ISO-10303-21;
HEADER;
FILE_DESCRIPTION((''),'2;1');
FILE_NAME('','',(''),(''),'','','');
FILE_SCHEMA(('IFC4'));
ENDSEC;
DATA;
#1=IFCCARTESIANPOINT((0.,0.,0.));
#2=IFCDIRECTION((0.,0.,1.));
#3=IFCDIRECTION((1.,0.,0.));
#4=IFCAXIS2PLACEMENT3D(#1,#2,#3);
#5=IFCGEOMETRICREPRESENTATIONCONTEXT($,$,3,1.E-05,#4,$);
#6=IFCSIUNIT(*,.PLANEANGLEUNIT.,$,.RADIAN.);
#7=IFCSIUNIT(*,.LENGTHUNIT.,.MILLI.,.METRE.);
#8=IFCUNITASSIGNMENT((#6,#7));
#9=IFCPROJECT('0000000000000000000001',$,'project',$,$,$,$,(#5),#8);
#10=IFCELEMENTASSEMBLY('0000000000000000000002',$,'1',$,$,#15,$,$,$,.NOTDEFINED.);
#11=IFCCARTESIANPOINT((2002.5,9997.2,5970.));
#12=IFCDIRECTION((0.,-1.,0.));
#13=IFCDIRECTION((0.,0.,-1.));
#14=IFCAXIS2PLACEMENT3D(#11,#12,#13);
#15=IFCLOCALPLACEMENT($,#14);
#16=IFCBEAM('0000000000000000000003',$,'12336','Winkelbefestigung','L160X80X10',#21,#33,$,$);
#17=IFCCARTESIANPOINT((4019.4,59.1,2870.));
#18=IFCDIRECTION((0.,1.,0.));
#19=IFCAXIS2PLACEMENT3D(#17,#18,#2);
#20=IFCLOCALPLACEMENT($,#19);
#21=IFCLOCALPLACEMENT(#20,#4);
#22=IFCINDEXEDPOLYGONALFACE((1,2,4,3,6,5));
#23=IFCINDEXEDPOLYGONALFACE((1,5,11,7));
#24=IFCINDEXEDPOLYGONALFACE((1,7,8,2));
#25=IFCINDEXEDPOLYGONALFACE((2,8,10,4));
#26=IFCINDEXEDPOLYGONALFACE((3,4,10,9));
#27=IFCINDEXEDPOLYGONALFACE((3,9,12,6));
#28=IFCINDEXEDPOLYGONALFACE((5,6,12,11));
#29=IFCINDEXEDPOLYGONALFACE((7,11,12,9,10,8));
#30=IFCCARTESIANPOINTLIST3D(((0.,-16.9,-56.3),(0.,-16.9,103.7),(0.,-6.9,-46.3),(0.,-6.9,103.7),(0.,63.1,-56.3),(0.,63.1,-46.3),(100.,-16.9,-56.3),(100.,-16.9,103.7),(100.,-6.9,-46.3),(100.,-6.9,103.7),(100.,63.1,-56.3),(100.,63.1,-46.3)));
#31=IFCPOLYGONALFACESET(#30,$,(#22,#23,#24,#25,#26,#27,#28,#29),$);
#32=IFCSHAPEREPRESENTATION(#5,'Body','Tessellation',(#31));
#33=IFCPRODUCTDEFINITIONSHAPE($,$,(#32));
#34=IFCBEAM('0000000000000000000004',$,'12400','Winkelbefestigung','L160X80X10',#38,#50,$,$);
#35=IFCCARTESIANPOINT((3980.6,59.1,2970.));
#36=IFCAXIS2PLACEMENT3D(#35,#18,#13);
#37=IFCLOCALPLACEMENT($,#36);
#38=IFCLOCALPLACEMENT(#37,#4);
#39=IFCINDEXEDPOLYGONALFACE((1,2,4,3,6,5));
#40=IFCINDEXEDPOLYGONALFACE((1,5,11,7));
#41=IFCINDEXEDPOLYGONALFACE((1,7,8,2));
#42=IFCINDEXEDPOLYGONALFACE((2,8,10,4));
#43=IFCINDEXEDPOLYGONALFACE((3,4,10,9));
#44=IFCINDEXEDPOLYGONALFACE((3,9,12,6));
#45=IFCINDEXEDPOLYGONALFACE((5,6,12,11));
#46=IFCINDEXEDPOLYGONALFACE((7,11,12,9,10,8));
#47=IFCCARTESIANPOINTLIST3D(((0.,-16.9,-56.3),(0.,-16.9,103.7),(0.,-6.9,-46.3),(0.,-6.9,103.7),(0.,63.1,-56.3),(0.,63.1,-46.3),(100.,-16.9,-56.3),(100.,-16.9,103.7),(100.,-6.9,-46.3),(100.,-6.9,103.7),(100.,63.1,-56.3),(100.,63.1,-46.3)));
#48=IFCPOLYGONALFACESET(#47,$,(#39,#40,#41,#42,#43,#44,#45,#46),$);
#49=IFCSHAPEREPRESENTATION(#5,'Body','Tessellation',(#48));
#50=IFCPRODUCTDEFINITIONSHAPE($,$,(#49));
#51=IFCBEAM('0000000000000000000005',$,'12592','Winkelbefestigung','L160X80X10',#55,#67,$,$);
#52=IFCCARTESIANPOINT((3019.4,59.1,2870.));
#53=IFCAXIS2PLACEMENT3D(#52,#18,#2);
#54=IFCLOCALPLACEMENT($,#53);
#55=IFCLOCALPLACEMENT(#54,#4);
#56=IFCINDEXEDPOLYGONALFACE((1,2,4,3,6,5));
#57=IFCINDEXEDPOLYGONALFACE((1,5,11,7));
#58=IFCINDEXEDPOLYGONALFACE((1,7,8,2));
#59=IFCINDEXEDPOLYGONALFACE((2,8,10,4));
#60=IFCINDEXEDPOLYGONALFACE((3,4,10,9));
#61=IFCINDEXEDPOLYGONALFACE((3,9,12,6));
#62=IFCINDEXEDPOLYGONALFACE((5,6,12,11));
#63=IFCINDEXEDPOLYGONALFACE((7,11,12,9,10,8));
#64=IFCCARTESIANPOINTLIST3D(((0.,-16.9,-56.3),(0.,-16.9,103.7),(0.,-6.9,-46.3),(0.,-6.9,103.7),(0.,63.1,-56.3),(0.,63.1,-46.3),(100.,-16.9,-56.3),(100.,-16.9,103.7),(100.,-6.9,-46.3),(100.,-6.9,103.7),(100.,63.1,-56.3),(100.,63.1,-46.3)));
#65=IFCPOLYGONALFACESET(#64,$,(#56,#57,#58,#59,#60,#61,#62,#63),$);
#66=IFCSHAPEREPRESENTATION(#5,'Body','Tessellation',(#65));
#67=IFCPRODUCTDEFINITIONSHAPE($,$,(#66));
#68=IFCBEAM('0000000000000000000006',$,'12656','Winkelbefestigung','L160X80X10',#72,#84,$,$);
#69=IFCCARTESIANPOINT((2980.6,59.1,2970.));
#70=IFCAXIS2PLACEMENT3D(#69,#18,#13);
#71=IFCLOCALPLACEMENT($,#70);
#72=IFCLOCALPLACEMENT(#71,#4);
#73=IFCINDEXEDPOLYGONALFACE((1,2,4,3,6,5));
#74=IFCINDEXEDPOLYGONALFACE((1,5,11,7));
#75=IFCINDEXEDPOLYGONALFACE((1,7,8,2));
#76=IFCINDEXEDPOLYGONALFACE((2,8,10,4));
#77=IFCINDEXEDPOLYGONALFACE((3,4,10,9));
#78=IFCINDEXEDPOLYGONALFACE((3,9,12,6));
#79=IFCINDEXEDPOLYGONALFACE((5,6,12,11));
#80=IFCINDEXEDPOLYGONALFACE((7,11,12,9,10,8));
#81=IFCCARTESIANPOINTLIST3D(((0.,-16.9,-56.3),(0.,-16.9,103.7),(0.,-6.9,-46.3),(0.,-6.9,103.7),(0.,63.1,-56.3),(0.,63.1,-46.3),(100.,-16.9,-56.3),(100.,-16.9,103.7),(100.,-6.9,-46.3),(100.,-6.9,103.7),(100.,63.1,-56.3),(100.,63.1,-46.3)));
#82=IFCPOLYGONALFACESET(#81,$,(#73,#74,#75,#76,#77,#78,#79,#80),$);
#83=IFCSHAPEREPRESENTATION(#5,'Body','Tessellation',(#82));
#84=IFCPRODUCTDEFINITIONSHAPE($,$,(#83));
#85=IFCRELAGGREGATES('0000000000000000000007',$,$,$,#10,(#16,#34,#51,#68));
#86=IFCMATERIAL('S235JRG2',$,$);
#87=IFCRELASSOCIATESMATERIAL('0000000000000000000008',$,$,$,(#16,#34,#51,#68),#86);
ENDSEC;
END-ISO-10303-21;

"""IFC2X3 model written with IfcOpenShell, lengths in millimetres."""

from ifc_helpers import new_model, si_unit, frame, origin_with_axes, place, context, project, polyline, outline, extrude, material, element, aggregate, save


model = new_model("IFC2X3")

# Units and contexts
context_of_model = context(None, 3, precision=1e-05, world=origin_with_axes())
ifc_project = project(units=[si_unit("PLANEANGLEUNIT", "RADIAN"), si_unit("LENGTHUNIT", "METRE", prefix="MILLI")], contexts=[context_of_model])

# Shared definitions
ifc_material = material(Name="S235JRG2")

# Element assembly, beams
assembly_1_placement = place(None, frame((2002.5, 9997.2, 5970.0), z_axis=(0.0, -1.0, 0.0), x_axis=(0.0, 0.0, -1.0)))
assembly_1 = element("IfcElementAssembly", 1, at=assembly_1_placement, Name="1", PredefinedType="NOTDEFINED")
placement_1 = place(None, frame((4019.4, 59.1, 2870.0), z_axis=(0.0, 1.0, 0.0), x_axis=(0.0, 0.0, 1.0)))
beam_1_placement = place(placement_1, origin_with_axes())
beam_1 = element("IfcBeam", 2, at=beam_1_placement, material=ifc_material, Name="12336", Description="Winkelbefestigung", ObjectType="L160X80X10", context=context_of_model, shape_type="SweptSolid", body=[
    extrude(outline(polyline([(-16.9, 103.7), (-16.9, -56.3), (63.1, -56.3), (63.1, -46.3), (-6.9, -46.3), (-6.9, 103.7), (-16.9, 103.7), (-16.9, 103.7)])), frame((0.0, 0.0, 0.0), z_axis=(1.0, 0.0, 0.0), x_axis=(0.0, 1.0, 0.0)), (0.0, 0.0, 1.0), 100.0),
])
placement_2 = place(None, frame((3980.6, 59.1, 2970.0), z_axis=(0.0, 1.0, 0.0), x_axis=(0.0, 0.0, -1.0)))
beam_2_placement = place(placement_2, origin_with_axes())
beam_2 = element("IfcBeam", 3, at=beam_2_placement, material=ifc_material, Name="12400", Description="Winkelbefestigung", ObjectType="L160X80X10", context=context_of_model, shape_type="SweptSolid", body=[
    extrude(outline(polyline([(-16.9, 103.7), (-16.9, -56.3), (63.1, -56.3), (63.1, -46.3), (-6.9, -46.3), (-6.9, 103.7), (-16.9, 103.7), (-16.9, 103.7)])), frame((0.0, 0.0, 0.0), z_axis=(1.0, 0.0, 0.0), x_axis=(0.0, 1.0, 0.0)), (0.0, 0.0, 1.0), 100.0),
])
placement_3 = place(None, frame((3019.4, 59.1, 2870.0), z_axis=(0.0, 1.0, 0.0), x_axis=(0.0, 0.0, 1.0)))
beam_3_placement = place(placement_3, origin_with_axes())
beam_3 = element("IfcBeam", 4, at=beam_3_placement, material=ifc_material, Name="12592", Description="Winkelbefestigung", ObjectType="L160X80X10", context=context_of_model, shape_type="SweptSolid", body=[
    extrude(outline(polyline([(-16.9, 103.7), (-16.9, -56.3), (63.1, -56.3), (63.1, -46.3), (-6.9, -46.3), (-6.9, 103.7), (-16.9, 103.7), (-16.9, 103.7)])), frame((0.0, 0.0, 0.0), z_axis=(1.0, 0.0, 0.0), x_axis=(0.0, 1.0, 0.0)), (0.0, 0.0, 1.0), 100.0),
])
placement_4 = place(None, frame((2980.6, 59.1, 2970.0), z_axis=(0.0, 1.0, 0.0), x_axis=(0.0, 0.0, -1.0)))
beam_4_placement = place(placement_4, origin_with_axes())
beam_4 = element("IfcBeam", 5, at=beam_4_placement, material=ifc_material, Name="12656", Description="Winkelbefestigung", ObjectType="L160X80X10", context=context_of_model, shape_type="SweptSolid", body=[
    extrude(outline(polyline([(-16.9, 103.7), (-16.9, -56.3), (63.1, -56.3), (63.1, -46.3), (-6.9, -46.3), (-6.9, 103.7), (-16.9, 103.7), (-16.9, 103.7)])), frame((0.0, 0.0, 0.0), z_axis=(1.0, 0.0, 0.0), x_axis=(0.0, 1.0, 0.0)), (0.0, 0.0, 1.0), 100.0),
])
aggregate(assembly_1, [beam_1, beam_2, beam_3, beam_4])

save(model, "model.ifc")
